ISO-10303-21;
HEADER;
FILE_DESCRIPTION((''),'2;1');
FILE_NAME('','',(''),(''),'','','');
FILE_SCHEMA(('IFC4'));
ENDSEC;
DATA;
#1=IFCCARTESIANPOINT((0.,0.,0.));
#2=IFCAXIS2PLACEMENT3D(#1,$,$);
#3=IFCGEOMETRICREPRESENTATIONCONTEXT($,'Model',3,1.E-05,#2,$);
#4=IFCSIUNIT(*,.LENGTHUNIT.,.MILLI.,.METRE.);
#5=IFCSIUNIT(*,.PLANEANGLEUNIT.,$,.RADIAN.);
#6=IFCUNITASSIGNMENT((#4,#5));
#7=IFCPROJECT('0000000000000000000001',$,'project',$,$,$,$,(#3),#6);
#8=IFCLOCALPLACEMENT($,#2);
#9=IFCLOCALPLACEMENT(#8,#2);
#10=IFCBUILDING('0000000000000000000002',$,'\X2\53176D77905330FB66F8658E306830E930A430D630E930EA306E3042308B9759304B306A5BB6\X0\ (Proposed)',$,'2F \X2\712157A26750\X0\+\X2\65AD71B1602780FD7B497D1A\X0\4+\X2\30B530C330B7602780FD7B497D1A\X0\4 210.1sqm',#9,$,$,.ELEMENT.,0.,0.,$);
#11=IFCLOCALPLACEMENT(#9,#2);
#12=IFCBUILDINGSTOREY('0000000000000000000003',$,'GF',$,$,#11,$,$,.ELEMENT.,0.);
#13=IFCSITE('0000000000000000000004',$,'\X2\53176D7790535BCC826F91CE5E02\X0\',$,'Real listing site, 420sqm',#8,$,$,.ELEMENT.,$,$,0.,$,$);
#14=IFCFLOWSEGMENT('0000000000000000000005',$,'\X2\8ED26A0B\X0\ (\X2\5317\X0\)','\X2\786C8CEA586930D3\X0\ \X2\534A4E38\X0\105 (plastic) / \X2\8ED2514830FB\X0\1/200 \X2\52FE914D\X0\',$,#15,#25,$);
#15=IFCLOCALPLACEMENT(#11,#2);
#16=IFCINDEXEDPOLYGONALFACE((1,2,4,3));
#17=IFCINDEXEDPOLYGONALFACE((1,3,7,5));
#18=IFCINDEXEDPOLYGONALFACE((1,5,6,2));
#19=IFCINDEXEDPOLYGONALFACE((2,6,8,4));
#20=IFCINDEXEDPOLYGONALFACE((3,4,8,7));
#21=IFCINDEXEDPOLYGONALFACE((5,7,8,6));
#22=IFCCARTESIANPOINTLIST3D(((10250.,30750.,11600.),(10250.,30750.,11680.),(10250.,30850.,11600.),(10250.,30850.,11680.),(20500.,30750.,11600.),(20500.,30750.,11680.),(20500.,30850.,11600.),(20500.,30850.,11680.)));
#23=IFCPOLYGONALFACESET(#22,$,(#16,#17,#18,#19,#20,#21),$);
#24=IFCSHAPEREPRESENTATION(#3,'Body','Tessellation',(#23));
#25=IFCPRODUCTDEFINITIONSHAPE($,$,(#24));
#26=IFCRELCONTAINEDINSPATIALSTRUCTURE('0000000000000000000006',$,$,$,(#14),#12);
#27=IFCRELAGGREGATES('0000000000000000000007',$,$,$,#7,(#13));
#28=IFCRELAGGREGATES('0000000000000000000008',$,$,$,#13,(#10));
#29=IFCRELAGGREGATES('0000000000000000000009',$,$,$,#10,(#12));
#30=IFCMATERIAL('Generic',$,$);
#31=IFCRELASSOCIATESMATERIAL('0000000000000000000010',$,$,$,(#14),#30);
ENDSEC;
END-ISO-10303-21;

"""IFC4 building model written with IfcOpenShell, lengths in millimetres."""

from ifc_helpers import new_model, si_unit, frame, frame_2d, origin, place, context, project, spatial, rectangle, extrude, material, element, save


model = new_model("IFC4")

# Units and contexts
model_context = context("Model", 3, precision=1e-05, world=origin())
ifc_project = project(units=[si_unit("LENGTHUNIT", "METRE", prefix="MILLI"), si_unit("PLANEANGLEUNIT", "RADIAN")], contexts=[model_context])

# Site, building, storey
site_placement = place(None, origin())
site = spatial("IfcSite", under=ifc_project, at=site_placement, Name="北海道富良野市", ObjectType="Real listing site, 420sqm", CompositionType="ELEMENT", RefElevation=0.0)
building_placement = place(site_placement, origin())
building = spatial("IfcBuilding", under=site, at=building_placement, Name="北海道・書斎とライブラリのある静かな家 (Proposed)", ObjectType="2F 無垢材+断熱性能等級4+サッシ性能等級4 210.1sqm", CompositionType="ELEMENT", ElevationOfRefHeight=0.0, ElevationOfTerrain=0.0)
storey_placement = place(building_placement, origin())
storey = spatial("IfcBuildingStorey", under=building, at=storey_placement, Name="GF", CompositionType="ELEMENT", Elevation=0.0)

# Shared definitions
ifc_material_1 = material(Name="Generic")

# Flow segment
flow_segment_1_placement = place(storey_placement, frame((5125.0, 15375.0, 5800.0)))
element("IfcFlowSegment", 1, at=flow_segment_1_placement, inside=storey, material=ifc_material_1, Name="軒樋 (北)", Description="硬質塩ビ 半丸105 (plastic) / 軒先・1/200 勾配", context=model_context, shape_type="SweptSolid", body=[
    extrude(rectangle(XDim=10250.0, YDim=100.0, at=frame_2d((5125.0, 50.0))), frame((5125.0, 15375.0, 5800.0)), (0.0, 0.0, 1.0), 80.0),
])

save(model, "model.ifc")
